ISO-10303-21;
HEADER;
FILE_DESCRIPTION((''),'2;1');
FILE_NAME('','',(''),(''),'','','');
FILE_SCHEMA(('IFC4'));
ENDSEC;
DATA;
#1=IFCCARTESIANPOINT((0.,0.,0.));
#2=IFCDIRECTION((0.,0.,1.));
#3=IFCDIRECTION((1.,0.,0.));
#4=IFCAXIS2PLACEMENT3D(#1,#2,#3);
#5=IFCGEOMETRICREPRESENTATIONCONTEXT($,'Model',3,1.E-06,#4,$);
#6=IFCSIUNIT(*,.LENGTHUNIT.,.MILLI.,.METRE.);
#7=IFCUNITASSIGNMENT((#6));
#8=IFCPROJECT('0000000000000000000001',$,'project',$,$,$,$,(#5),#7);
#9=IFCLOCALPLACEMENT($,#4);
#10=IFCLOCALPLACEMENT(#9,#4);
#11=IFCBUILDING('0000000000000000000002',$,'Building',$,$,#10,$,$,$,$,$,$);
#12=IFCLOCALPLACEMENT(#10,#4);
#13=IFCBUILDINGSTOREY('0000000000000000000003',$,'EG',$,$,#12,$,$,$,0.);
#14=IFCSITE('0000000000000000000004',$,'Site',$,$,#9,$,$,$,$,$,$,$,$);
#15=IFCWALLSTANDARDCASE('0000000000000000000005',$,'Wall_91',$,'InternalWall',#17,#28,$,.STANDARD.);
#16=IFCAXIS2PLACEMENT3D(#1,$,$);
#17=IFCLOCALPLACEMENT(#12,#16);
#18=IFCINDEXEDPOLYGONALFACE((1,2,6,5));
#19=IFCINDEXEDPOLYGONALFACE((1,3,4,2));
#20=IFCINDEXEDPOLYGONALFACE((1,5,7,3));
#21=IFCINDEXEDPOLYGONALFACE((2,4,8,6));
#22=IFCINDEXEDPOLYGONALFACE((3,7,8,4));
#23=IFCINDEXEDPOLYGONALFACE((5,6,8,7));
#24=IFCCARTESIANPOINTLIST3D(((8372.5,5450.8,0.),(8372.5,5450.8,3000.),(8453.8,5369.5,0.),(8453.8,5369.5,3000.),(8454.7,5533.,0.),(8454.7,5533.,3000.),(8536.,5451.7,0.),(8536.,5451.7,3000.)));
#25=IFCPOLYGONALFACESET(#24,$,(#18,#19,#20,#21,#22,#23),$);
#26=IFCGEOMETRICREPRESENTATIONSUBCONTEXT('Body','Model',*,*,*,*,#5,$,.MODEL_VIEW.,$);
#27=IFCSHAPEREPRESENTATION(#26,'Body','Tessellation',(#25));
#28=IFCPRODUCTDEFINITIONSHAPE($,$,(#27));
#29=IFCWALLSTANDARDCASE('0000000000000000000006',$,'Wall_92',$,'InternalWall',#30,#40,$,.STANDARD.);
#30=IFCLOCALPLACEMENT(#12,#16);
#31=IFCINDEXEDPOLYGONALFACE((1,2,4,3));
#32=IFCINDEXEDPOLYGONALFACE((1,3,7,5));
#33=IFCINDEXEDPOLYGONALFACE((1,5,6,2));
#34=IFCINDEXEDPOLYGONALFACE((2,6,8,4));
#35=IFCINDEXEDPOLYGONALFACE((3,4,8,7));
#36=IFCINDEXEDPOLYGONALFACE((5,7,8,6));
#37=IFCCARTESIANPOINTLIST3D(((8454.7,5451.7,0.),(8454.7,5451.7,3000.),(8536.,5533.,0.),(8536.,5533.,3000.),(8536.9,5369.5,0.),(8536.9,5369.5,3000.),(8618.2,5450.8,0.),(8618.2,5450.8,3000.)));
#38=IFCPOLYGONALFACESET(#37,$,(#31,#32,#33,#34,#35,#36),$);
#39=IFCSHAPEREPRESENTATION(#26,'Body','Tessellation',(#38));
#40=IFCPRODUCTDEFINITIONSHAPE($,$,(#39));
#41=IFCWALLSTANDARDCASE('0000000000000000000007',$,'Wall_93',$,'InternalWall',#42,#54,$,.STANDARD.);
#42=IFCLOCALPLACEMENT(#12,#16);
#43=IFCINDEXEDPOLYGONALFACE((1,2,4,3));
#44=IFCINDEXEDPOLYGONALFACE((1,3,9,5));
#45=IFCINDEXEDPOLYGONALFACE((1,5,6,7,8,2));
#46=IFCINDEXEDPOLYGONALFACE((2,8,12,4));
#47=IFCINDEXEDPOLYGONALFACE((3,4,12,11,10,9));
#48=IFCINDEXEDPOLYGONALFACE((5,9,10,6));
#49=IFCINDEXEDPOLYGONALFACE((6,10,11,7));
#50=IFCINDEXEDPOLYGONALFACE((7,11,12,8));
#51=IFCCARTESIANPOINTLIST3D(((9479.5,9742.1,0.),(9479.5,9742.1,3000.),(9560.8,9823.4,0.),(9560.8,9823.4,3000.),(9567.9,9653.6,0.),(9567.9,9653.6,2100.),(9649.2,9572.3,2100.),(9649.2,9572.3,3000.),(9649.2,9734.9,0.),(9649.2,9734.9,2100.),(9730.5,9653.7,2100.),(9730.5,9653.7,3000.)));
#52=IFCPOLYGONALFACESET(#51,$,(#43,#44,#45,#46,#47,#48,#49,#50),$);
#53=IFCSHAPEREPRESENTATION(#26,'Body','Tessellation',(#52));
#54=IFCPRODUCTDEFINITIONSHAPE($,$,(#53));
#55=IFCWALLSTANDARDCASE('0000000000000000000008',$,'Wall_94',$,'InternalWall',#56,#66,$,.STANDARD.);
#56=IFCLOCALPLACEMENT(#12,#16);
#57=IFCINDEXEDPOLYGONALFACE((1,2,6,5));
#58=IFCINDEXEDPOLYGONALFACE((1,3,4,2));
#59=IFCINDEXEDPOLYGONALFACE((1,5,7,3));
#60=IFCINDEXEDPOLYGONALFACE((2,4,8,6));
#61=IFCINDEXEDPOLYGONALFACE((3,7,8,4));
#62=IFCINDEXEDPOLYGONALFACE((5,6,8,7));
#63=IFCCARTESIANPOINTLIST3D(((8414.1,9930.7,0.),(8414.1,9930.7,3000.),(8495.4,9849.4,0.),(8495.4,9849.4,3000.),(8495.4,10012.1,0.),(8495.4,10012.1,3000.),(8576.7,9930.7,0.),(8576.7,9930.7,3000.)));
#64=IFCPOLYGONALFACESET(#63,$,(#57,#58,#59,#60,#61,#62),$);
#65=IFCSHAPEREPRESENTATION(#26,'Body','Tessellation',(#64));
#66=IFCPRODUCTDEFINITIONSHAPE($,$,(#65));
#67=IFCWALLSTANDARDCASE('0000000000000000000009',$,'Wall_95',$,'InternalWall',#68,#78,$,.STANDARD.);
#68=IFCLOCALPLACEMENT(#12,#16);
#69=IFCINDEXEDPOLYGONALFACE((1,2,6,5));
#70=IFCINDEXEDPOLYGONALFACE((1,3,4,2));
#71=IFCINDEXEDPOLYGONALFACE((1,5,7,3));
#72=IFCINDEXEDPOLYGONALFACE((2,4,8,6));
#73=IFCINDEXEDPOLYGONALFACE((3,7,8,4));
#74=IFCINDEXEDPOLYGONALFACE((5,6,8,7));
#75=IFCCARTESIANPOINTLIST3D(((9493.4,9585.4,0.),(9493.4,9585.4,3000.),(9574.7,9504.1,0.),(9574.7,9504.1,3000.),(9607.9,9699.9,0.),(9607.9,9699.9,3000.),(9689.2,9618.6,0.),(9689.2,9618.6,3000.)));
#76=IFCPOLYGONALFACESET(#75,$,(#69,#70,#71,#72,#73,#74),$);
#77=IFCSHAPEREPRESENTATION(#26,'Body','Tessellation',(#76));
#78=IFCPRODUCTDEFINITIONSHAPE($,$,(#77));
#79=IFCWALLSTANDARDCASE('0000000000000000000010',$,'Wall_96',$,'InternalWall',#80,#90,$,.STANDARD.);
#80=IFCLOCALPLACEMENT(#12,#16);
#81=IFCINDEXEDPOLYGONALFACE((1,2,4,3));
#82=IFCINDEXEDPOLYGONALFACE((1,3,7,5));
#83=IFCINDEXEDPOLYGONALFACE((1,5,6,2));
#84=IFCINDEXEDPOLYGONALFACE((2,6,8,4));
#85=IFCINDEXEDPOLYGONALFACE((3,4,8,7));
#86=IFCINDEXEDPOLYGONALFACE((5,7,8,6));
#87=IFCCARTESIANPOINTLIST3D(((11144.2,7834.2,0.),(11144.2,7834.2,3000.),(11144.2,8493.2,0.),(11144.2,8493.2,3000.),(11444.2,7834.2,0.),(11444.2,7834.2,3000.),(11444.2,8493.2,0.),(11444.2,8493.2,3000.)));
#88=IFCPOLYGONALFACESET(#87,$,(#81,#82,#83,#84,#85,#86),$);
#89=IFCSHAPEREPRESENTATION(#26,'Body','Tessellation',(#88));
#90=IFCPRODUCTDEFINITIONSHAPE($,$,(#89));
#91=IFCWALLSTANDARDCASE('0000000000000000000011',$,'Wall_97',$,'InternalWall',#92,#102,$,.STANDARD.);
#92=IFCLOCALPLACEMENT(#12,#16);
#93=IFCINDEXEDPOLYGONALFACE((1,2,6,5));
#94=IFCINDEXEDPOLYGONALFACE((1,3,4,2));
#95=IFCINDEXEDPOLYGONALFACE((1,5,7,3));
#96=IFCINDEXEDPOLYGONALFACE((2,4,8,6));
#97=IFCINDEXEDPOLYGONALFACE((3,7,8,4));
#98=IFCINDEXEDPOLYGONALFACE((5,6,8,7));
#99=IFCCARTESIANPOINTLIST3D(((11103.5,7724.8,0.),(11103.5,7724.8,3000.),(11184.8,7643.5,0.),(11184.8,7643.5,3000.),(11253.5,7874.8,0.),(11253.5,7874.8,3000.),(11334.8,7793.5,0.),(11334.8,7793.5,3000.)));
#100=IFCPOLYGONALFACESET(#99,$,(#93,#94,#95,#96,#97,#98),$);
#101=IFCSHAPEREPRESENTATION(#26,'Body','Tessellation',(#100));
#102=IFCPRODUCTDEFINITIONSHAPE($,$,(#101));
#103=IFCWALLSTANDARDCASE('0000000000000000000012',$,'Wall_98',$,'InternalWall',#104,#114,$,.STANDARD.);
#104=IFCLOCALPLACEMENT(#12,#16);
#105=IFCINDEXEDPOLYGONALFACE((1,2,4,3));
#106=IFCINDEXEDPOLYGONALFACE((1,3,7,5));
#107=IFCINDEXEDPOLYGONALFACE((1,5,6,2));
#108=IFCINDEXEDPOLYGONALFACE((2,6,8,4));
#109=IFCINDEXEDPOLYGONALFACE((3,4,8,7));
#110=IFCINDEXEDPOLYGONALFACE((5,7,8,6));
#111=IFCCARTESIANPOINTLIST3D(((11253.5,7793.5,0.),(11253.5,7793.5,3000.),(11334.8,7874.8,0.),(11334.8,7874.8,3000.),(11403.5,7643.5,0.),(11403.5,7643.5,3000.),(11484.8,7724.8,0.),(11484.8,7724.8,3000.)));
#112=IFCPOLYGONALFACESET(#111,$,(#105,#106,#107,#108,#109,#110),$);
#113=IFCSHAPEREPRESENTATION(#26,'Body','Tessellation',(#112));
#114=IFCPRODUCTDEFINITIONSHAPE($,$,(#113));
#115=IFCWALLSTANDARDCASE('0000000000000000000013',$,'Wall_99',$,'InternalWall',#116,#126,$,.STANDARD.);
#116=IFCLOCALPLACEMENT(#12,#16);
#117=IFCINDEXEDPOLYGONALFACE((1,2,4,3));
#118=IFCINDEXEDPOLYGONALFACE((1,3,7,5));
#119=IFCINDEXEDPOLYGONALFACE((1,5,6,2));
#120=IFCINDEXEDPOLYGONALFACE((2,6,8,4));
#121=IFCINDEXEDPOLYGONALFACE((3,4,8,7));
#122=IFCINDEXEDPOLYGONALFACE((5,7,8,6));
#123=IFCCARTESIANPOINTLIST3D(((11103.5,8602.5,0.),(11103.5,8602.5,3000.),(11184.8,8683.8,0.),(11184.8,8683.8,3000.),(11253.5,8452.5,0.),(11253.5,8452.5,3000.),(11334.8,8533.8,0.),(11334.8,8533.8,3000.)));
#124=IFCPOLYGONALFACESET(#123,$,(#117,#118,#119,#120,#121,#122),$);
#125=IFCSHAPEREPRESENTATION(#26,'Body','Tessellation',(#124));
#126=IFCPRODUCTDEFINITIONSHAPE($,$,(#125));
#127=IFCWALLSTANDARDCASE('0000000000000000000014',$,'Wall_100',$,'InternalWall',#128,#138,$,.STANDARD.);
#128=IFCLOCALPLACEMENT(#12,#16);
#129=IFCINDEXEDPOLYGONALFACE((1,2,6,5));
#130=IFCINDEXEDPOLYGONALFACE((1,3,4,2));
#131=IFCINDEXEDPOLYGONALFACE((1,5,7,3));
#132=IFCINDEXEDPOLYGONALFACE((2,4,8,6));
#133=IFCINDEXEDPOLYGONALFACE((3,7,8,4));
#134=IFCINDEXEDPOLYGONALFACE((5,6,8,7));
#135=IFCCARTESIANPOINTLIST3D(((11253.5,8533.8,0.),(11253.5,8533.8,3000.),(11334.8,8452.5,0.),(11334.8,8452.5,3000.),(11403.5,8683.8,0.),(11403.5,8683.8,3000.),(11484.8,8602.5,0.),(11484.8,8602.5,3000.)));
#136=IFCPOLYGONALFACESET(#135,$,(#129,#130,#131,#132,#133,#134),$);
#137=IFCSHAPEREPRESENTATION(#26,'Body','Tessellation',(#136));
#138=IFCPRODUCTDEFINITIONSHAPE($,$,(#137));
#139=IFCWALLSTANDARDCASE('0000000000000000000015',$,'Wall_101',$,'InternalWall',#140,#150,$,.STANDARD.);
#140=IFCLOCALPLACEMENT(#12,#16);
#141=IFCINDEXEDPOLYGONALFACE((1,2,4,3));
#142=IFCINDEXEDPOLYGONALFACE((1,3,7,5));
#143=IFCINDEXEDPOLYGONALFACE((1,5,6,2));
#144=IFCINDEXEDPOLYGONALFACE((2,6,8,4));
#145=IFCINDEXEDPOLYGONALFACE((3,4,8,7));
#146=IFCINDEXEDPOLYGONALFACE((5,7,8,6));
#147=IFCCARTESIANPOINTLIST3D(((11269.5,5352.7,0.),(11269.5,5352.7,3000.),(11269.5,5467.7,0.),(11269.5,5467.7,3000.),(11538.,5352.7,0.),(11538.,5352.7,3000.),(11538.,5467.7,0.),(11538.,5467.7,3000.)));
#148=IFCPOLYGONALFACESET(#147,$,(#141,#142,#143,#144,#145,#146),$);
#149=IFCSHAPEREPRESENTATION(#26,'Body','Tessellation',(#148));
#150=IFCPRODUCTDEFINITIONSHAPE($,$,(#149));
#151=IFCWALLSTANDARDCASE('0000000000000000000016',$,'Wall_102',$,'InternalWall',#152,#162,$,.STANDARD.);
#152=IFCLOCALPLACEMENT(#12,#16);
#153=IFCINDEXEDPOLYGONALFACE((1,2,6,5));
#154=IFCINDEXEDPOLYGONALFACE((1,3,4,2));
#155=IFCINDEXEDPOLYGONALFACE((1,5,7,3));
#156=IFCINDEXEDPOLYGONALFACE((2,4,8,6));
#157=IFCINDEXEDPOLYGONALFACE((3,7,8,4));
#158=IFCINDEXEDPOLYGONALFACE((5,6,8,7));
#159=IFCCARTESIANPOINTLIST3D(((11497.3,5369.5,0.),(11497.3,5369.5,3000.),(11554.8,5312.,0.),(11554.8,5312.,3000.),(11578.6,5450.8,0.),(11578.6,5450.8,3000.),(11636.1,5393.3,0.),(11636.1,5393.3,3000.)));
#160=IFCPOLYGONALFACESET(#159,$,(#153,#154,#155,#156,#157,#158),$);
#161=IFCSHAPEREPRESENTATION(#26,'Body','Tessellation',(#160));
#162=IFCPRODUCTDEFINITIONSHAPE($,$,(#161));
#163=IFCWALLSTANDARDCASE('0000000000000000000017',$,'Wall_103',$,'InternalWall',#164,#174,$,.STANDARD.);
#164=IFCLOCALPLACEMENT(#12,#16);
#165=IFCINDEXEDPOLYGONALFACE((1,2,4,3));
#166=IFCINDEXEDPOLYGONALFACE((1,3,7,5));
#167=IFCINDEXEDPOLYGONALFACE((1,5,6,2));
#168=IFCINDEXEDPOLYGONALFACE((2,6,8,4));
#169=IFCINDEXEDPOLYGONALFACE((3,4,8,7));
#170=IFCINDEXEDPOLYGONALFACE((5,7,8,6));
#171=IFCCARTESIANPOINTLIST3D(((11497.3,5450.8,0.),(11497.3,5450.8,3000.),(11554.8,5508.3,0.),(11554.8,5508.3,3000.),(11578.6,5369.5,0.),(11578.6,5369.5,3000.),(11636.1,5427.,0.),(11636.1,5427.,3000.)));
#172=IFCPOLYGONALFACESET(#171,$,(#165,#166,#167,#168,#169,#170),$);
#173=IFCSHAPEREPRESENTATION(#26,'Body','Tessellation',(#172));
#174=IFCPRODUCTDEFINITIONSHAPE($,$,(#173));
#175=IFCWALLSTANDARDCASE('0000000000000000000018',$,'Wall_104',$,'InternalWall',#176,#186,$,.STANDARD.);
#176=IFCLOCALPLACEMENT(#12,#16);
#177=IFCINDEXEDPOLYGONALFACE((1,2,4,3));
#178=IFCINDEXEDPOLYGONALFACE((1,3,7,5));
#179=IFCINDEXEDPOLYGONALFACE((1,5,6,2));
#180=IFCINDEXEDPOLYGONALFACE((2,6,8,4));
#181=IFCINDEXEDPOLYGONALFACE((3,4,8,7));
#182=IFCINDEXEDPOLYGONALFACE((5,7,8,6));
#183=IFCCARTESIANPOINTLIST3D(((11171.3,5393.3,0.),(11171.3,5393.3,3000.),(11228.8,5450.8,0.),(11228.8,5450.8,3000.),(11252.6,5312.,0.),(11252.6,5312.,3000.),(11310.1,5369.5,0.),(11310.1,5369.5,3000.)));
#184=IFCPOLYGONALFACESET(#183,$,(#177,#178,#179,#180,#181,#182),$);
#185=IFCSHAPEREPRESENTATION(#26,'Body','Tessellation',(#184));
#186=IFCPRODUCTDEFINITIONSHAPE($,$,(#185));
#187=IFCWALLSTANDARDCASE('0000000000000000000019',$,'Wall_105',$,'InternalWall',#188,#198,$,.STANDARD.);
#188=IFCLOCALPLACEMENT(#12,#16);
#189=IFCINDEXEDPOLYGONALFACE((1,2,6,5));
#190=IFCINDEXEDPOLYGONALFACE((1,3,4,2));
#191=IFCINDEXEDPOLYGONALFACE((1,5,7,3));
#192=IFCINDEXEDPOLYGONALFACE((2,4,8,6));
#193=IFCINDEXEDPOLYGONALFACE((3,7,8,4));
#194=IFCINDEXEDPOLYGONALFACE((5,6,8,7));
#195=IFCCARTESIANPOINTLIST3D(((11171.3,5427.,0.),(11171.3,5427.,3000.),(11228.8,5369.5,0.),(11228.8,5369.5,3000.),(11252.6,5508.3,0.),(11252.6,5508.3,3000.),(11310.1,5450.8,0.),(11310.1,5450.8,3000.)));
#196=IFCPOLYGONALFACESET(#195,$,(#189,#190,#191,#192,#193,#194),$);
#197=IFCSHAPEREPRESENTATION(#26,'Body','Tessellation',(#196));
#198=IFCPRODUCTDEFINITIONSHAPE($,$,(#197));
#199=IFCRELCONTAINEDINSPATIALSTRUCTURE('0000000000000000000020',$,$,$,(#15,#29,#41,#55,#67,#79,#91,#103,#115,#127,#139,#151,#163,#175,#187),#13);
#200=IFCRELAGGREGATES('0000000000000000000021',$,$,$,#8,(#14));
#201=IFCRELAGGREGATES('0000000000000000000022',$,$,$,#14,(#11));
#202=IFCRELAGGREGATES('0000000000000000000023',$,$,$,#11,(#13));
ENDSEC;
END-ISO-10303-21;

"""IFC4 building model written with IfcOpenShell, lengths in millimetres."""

from ifc_helpers import new_model, si_unit, frame, origin_with_axes, place, context, subcontext, project, spatial, rectangle, extrude, element, save


model = new_model("IFC4")

# Units and contexts
model_context = context("Model", 3, precision=1e-06, world=origin_with_axes())
body_context = subcontext(model_context, "Body", "Model", "MODEL_VIEW")
ifc_project = project(units=[si_unit("LENGTHUNIT", "METRE", prefix="MILLI")], contexts=[model_context])

# Site, building, storey
site_placement = place(None, origin_with_axes())
site = spatial("IfcSite", under=ifc_project, at=site_placement, Name="Site")
building_placement = place(site_placement, origin_with_axes())
building = spatial("IfcBuilding", under=site, at=building_placement, Name="Building")
storey_placement = place(building_placement, origin_with_axes())
storey = spatial("IfcBuildingStorey", under=building, at=storey_placement, Name="EG", Elevation=0.0)

# Walls
wall_1_placement = place(storey_placement, origin_with_axes())
element("IfcWallStandardCase", 1, at=wall_1_placement, inside=storey, Name="Wall_91", ObjectType="InternalWall", PredefinedType="STANDARD", context=body_context, shape_type="SweptSolid", body=[
    extrude(rectangle(XDim=116.2, YDim=115.0), frame((8454.3, 5451.3, 0.0), z_axis=(0.0, 0.0, 1.0), x_axis=(-0.707107, -0.707107, 0.0)), (0.0, 0.0, 1.0), 3000.0),
])
wall_2_placement = place(storey_placement, origin_with_axes())
element("IfcWallStandardCase", 2, at=wall_2_placement, inside=storey, Name="Wall_92", ObjectType="InternalWall", PredefinedType="STANDARD", context=body_context, shape_type="SweptSolid", body=[
    extrude(rectangle(XDim=116.2, YDim=115.0), frame((8536.5, 5451.3, 0.0), z_axis=(0.0, 0.0, 1.0), x_axis=(-0.707107, 0.707107, 0.0)), (0.0, 0.0, 1.0), 3000.0),
])

# Wall, opening
wall_3_placement = place(storey_placement, origin_with_axes())
wall_3 = element("IfcWallStandardCase", 3, at=wall_3_placement, inside=storey, Name="Wall_93", ObjectType="InternalWall", PredefinedType="STANDARD", context=body_context, shape_type="SweptSolid", body=[
    extrude(rectangle(XDim=240.0, YDim=115.0), frame((9605.0, 9697.9, 0.0), z_axis=(0.0, 0.0, 1.0), x_axis=(-0.707107, 0.707107, 0.0)), (0.0, 0.0, 1.0), 3000.0),
])
opening_1_placement = place(wall_3_placement, origin_with_axes())
element("IfcOpeningElement", 4, at=opening_1_placement, inside=storey, cuts=wall_3, context=body_context, shape_type="SweptSolid", body=[
    extrude(rectangle(XDim=1302.9, YDim=115.0), frame((10069.2, 9233.6, 0.0), z_axis=(0.0, 0.0, 1.0), x_axis=(-0.707107, 0.707107, 0.0)), (0.0, 0.0, 1.0), 2100.0),
])

# Walls
wall_4_placement = place(storey_placement, origin_with_axes())
element("IfcWallStandardCase", 5, at=wall_4_placement, inside=storey, Name="Wall_94", ObjectType="InternalWall", PredefinedType="STANDARD", context=body_context, shape_type="SweptSolid", body=[
    extrude(rectangle(XDim=115.0, YDim=115.0), frame((8495.4, 9930.7, 0.0), z_axis=(0.0, 0.0, 1.0), x_axis=(-0.707107, 0.707107, 0.0)), (0.0, 0.0, 1.0), 3000.0),
])
wall_5_placement = place(storey_placement, origin_with_axes())
element("IfcWallStandardCase", 6, at=wall_5_placement, inside=storey, Name="Wall_95", ObjectType="InternalWall", PredefinedType="STANDARD", context=body_context, shape_type="SweptSolid", body=[
    extrude(rectangle(XDim=161.9, YDim=115.0), frame((9591.3, 9602.0, 0.0), z_axis=(0.0, 0.0, 1.0), x_axis=(-0.707107, -0.707107, 0.0)), (0.0, 0.0, 1.0), 3000.0),
])
wall_6_placement = place(storey_placement, origin_with_axes())
element("IfcWallStandardCase", 7, at=wall_6_placement, inside=storey, Name="Wall_96", ObjectType="InternalWall", PredefinedType="STANDARD", context=body_context, shape_type="SweptSolid", body=[
    extrude(rectangle(XDim=659.0, YDim=300.0), frame((11294.2, 8163.7, 0.0), z_axis=(0.0, 0.0, 1.0), x_axis=(0.0, 1.0, 0.0)), (0.0, 0.0, 1.0), 3000.0),
])
wall_7_placement = place(storey_placement, origin_with_axes())
element("IfcWallStandardCase", 8, at=wall_7_placement, inside=storey, Name="Wall_97", ObjectType="InternalWall", PredefinedType="STANDARD", context=body_context, shape_type="SweptSolid", body=[
    extrude(rectangle(XDim=212.1, YDim=115.0), frame((11219.2, 7759.2, 0.0), z_axis=(0.0, 0.0, 1.0), x_axis=(-0.707107, -0.707107, 0.0)), (0.0, 0.0, 1.0), 3000.0),
])
wall_8_placement = place(storey_placement, origin_with_axes())
element("IfcWallStandardCase", 9, at=wall_8_placement, inside=storey, Name="Wall_98", ObjectType="InternalWall", PredefinedType="STANDARD", context=body_context, shape_type="SweptSolid", body=[
    extrude(rectangle(XDim=212.1, YDim=115.0), frame((11369.2, 7759.2, 0.0), z_axis=(0.0, 0.0, 1.0), x_axis=(0.707107, -0.707107, 0.0)), (0.0, 0.0, 1.0), 3000.0),
])
wall_9_placement = place(storey_placement, origin_with_axes())
element("IfcWallStandardCase", 10, at=wall_9_placement, inside=storey, Name="Wall_99", ObjectType="InternalWall", PredefinedType="STANDARD", context=body_context, shape_type="SweptSolid", body=[
    extrude(rectangle(XDim=212.1, YDim=115.0), frame((11219.2, 8568.2, 0.0), z_axis=(0.0, 0.0, 1.0), x_axis=(-0.707107, 0.707107, 0.0)), (0.0, 0.0, 1.0), 3000.0),
])
wall_10_placement = place(storey_placement, origin_with_axes())
element("IfcWallStandardCase", 11, at=wall_10_placement, inside=storey, Name="Wall_100", ObjectType="InternalWall", PredefinedType="STANDARD", context=body_context, shape_type="SweptSolid", body=[
    extrude(rectangle(XDim=212.1, YDim=115.0), frame((11369.2, 8568.2, 0.0), z_axis=(0.0, 0.0, 1.0), x_axis=(0.707107, 0.707107, 0.0)), (0.0, 0.0, 1.0), 3000.0),
])
wall_11_placement = place(storey_placement, origin_with_axes())
element("IfcWallStandardCase", 12, at=wall_11_placement, inside=storey, Name="Wall_101", ObjectType="InternalWall", PredefinedType="STANDARD", context=body_context, shape_type="SweptSolid", body=[
    extrude(rectangle(XDim=268.5, YDim=115.0), frame((11403.7, 5410.2, 0.0), z_axis=(0.0, 0.0, 1.0), x_axis=(-1.0, 0.0, 0.0)), (0.0, 0.0, 1.0), 3000.0),
])
wall_12_placement = place(storey_placement, origin_with_axes())
element("IfcWallStandardCase", 13, at=wall_12_placement, inside=storey, Name="Wall_102", ObjectType="InternalWall", PredefinedType="STANDARD", context=body_context, shape_type="SweptSolid", body=[
    extrude(rectangle(XDim=81.3, YDim=115.0), frame((11566.7, 5381.4, 0.0), z_axis=(0.0, 0.0, 1.0), x_axis=(0.707107, -0.707107, 0.0)), (0.0, 0.0, 1.0), 3000.0),
])
wall_13_placement = place(storey_placement, origin_with_axes())
element("IfcWallStandardCase", 14, at=wall_13_placement, inside=storey, Name="Wall_103", ObjectType="InternalWall", PredefinedType="STANDARD", context=body_context, shape_type="SweptSolid", body=[
    extrude(rectangle(XDim=81.3, YDim=115.0), frame((11566.7, 5438.9, 0.0), z_axis=(0.0, 0.0, 1.0), x_axis=(0.707107, 0.707107, 0.0)), (0.0, 0.0, 1.0), 3000.0),
])
wall_14_placement = place(storey_placement, origin_with_axes())
element("IfcWallStandardCase", 15, at=wall_14_placement, inside=storey, Name="Wall_104", ObjectType="InternalWall", PredefinedType="STANDARD", context=body_context, shape_type="SweptSolid", body=[
    extrude(rectangle(XDim=81.3, YDim=115.0), frame((11240.7, 5381.4, 0.0), z_axis=(0.0, 0.0, 1.0), x_axis=(-0.707107, -0.707107, 0.0)), (0.0, 0.0, 1.0), 3000.0),
])
wall_15_placement = place(storey_placement, origin_with_axes())
element("IfcWallStandardCase", 16, at=wall_15_placement, inside=storey, Name="Wall_105", ObjectType="InternalWall", PredefinedType="STANDARD", context=body_context, shape_type="SweptSolid", body=[
    extrude(rectangle(XDim=81.3, YDim=115.0), frame((11240.7, 5438.9, 0.0), z_axis=(0.0, 0.0, 1.0), x_axis=(-0.707107, 0.707107, 0.0)), (0.0, 0.0, 1.0), 3000.0),
])

save(model, "model.ifc")
